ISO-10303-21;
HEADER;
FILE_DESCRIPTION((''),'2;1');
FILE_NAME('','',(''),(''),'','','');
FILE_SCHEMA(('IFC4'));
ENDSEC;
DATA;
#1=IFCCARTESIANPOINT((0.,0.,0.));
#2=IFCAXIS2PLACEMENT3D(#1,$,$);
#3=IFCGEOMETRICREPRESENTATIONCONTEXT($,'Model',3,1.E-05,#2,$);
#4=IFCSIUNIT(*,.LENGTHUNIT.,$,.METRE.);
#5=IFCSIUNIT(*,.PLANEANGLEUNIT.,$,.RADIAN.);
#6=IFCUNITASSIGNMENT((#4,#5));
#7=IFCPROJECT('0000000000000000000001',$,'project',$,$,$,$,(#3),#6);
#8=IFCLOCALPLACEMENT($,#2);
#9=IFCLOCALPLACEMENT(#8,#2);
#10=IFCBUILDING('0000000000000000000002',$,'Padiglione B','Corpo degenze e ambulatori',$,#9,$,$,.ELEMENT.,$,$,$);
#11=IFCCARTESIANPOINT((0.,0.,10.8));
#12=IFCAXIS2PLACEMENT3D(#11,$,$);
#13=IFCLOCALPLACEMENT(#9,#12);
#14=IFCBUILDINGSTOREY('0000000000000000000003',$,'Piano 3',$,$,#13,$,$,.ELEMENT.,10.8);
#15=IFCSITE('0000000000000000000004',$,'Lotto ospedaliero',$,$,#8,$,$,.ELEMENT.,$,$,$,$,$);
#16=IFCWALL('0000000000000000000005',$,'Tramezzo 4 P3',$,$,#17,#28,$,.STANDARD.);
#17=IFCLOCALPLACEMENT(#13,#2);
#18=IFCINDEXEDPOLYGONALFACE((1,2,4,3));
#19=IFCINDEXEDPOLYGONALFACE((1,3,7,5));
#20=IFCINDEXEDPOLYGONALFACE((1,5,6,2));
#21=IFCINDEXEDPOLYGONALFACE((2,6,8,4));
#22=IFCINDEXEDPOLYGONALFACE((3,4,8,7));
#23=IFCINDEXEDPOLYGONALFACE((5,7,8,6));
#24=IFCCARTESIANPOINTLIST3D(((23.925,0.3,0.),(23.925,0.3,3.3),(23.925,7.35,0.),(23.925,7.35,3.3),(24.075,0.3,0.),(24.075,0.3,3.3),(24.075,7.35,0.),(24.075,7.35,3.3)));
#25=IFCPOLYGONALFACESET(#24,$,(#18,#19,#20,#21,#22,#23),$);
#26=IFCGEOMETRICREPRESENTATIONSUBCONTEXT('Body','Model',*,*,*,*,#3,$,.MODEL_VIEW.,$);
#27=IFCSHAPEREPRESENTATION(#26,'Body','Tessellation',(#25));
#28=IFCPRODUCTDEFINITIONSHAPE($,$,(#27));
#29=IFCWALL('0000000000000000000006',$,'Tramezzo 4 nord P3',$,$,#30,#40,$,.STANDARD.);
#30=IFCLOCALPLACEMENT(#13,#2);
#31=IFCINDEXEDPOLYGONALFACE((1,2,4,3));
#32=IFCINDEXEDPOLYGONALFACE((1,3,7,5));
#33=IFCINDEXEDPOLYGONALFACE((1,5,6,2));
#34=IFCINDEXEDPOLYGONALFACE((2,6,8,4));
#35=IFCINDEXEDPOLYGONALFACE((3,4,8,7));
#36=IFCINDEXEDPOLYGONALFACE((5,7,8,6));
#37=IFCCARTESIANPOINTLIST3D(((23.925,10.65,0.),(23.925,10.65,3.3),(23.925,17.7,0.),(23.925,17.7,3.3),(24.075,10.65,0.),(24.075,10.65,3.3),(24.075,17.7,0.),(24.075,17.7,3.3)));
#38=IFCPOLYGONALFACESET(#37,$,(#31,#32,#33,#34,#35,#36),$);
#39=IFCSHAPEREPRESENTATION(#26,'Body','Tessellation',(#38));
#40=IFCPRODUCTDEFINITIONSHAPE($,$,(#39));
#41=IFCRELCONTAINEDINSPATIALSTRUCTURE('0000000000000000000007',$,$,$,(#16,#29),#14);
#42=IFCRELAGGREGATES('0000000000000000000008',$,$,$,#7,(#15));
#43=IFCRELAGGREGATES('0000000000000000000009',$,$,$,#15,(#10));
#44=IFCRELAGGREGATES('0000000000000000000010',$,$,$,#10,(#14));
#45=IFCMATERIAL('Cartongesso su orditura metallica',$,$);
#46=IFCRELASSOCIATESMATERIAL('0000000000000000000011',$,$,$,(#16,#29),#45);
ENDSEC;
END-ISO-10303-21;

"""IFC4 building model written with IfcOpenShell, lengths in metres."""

from ifc_helpers import new_model, si_unit, frame, frame_2d, origin, place, context, subcontext, project, spatial, rectangle, extrude, material, element, save


model = new_model("IFC4")

# Units and contexts
model_context = context("Model", 3, precision=1e-05, world=origin())
body_context = subcontext(model_context, "Body", "Model", "MODEL_VIEW")
ifc_project = project(units=[si_unit("LENGTHUNIT", "METRE"), si_unit("PLANEANGLEUNIT", "RADIAN")], contexts=[model_context])

# Site, building, storey
site_placement = place(None, origin())
site = spatial("IfcSite", under=ifc_project, at=site_placement, Name="Lotto ospedaliero", CompositionType="ELEMENT")
building_placement = place(site_placement, origin())
building = spatial("IfcBuilding", under=site, at=building_placement, Name="Padiglione B", Description="Corpo degenze e ambulatori", CompositionType="ELEMENT")
storey_placement = place(building_placement, frame((0.0, 0.0, 10.8)))
storey = spatial("IfcBuildingStorey", under=building, at=storey_placement, Name="Piano 3", CompositionType="ELEMENT", Elevation=10.8)

# Walls
ifc_material_1 = material(Name="Cartongesso su orditura metallica")
for number, where, name in (
    (1, (23.925, 0.3, 0.0), "Tramezzo 4 P3"),
    (2, (23.925, 10.65, 0.0), "Tramezzo 4 nord P3"),
):
    element("IfcWall", number, at=place(storey_placement, frame(where)), inside=storey, material=ifc_material_1, Name=name, PredefinedType="STANDARD", context=body_context, shape_type="SweptSolid", body=[
        extrude(rectangle(XDim=0.15, YDim=7.05, at=frame_2d((0.075, 3.525))), origin(), (0.0, 0.0, 1.0), 3.3),
    ])

save(model, "model.ifc")
